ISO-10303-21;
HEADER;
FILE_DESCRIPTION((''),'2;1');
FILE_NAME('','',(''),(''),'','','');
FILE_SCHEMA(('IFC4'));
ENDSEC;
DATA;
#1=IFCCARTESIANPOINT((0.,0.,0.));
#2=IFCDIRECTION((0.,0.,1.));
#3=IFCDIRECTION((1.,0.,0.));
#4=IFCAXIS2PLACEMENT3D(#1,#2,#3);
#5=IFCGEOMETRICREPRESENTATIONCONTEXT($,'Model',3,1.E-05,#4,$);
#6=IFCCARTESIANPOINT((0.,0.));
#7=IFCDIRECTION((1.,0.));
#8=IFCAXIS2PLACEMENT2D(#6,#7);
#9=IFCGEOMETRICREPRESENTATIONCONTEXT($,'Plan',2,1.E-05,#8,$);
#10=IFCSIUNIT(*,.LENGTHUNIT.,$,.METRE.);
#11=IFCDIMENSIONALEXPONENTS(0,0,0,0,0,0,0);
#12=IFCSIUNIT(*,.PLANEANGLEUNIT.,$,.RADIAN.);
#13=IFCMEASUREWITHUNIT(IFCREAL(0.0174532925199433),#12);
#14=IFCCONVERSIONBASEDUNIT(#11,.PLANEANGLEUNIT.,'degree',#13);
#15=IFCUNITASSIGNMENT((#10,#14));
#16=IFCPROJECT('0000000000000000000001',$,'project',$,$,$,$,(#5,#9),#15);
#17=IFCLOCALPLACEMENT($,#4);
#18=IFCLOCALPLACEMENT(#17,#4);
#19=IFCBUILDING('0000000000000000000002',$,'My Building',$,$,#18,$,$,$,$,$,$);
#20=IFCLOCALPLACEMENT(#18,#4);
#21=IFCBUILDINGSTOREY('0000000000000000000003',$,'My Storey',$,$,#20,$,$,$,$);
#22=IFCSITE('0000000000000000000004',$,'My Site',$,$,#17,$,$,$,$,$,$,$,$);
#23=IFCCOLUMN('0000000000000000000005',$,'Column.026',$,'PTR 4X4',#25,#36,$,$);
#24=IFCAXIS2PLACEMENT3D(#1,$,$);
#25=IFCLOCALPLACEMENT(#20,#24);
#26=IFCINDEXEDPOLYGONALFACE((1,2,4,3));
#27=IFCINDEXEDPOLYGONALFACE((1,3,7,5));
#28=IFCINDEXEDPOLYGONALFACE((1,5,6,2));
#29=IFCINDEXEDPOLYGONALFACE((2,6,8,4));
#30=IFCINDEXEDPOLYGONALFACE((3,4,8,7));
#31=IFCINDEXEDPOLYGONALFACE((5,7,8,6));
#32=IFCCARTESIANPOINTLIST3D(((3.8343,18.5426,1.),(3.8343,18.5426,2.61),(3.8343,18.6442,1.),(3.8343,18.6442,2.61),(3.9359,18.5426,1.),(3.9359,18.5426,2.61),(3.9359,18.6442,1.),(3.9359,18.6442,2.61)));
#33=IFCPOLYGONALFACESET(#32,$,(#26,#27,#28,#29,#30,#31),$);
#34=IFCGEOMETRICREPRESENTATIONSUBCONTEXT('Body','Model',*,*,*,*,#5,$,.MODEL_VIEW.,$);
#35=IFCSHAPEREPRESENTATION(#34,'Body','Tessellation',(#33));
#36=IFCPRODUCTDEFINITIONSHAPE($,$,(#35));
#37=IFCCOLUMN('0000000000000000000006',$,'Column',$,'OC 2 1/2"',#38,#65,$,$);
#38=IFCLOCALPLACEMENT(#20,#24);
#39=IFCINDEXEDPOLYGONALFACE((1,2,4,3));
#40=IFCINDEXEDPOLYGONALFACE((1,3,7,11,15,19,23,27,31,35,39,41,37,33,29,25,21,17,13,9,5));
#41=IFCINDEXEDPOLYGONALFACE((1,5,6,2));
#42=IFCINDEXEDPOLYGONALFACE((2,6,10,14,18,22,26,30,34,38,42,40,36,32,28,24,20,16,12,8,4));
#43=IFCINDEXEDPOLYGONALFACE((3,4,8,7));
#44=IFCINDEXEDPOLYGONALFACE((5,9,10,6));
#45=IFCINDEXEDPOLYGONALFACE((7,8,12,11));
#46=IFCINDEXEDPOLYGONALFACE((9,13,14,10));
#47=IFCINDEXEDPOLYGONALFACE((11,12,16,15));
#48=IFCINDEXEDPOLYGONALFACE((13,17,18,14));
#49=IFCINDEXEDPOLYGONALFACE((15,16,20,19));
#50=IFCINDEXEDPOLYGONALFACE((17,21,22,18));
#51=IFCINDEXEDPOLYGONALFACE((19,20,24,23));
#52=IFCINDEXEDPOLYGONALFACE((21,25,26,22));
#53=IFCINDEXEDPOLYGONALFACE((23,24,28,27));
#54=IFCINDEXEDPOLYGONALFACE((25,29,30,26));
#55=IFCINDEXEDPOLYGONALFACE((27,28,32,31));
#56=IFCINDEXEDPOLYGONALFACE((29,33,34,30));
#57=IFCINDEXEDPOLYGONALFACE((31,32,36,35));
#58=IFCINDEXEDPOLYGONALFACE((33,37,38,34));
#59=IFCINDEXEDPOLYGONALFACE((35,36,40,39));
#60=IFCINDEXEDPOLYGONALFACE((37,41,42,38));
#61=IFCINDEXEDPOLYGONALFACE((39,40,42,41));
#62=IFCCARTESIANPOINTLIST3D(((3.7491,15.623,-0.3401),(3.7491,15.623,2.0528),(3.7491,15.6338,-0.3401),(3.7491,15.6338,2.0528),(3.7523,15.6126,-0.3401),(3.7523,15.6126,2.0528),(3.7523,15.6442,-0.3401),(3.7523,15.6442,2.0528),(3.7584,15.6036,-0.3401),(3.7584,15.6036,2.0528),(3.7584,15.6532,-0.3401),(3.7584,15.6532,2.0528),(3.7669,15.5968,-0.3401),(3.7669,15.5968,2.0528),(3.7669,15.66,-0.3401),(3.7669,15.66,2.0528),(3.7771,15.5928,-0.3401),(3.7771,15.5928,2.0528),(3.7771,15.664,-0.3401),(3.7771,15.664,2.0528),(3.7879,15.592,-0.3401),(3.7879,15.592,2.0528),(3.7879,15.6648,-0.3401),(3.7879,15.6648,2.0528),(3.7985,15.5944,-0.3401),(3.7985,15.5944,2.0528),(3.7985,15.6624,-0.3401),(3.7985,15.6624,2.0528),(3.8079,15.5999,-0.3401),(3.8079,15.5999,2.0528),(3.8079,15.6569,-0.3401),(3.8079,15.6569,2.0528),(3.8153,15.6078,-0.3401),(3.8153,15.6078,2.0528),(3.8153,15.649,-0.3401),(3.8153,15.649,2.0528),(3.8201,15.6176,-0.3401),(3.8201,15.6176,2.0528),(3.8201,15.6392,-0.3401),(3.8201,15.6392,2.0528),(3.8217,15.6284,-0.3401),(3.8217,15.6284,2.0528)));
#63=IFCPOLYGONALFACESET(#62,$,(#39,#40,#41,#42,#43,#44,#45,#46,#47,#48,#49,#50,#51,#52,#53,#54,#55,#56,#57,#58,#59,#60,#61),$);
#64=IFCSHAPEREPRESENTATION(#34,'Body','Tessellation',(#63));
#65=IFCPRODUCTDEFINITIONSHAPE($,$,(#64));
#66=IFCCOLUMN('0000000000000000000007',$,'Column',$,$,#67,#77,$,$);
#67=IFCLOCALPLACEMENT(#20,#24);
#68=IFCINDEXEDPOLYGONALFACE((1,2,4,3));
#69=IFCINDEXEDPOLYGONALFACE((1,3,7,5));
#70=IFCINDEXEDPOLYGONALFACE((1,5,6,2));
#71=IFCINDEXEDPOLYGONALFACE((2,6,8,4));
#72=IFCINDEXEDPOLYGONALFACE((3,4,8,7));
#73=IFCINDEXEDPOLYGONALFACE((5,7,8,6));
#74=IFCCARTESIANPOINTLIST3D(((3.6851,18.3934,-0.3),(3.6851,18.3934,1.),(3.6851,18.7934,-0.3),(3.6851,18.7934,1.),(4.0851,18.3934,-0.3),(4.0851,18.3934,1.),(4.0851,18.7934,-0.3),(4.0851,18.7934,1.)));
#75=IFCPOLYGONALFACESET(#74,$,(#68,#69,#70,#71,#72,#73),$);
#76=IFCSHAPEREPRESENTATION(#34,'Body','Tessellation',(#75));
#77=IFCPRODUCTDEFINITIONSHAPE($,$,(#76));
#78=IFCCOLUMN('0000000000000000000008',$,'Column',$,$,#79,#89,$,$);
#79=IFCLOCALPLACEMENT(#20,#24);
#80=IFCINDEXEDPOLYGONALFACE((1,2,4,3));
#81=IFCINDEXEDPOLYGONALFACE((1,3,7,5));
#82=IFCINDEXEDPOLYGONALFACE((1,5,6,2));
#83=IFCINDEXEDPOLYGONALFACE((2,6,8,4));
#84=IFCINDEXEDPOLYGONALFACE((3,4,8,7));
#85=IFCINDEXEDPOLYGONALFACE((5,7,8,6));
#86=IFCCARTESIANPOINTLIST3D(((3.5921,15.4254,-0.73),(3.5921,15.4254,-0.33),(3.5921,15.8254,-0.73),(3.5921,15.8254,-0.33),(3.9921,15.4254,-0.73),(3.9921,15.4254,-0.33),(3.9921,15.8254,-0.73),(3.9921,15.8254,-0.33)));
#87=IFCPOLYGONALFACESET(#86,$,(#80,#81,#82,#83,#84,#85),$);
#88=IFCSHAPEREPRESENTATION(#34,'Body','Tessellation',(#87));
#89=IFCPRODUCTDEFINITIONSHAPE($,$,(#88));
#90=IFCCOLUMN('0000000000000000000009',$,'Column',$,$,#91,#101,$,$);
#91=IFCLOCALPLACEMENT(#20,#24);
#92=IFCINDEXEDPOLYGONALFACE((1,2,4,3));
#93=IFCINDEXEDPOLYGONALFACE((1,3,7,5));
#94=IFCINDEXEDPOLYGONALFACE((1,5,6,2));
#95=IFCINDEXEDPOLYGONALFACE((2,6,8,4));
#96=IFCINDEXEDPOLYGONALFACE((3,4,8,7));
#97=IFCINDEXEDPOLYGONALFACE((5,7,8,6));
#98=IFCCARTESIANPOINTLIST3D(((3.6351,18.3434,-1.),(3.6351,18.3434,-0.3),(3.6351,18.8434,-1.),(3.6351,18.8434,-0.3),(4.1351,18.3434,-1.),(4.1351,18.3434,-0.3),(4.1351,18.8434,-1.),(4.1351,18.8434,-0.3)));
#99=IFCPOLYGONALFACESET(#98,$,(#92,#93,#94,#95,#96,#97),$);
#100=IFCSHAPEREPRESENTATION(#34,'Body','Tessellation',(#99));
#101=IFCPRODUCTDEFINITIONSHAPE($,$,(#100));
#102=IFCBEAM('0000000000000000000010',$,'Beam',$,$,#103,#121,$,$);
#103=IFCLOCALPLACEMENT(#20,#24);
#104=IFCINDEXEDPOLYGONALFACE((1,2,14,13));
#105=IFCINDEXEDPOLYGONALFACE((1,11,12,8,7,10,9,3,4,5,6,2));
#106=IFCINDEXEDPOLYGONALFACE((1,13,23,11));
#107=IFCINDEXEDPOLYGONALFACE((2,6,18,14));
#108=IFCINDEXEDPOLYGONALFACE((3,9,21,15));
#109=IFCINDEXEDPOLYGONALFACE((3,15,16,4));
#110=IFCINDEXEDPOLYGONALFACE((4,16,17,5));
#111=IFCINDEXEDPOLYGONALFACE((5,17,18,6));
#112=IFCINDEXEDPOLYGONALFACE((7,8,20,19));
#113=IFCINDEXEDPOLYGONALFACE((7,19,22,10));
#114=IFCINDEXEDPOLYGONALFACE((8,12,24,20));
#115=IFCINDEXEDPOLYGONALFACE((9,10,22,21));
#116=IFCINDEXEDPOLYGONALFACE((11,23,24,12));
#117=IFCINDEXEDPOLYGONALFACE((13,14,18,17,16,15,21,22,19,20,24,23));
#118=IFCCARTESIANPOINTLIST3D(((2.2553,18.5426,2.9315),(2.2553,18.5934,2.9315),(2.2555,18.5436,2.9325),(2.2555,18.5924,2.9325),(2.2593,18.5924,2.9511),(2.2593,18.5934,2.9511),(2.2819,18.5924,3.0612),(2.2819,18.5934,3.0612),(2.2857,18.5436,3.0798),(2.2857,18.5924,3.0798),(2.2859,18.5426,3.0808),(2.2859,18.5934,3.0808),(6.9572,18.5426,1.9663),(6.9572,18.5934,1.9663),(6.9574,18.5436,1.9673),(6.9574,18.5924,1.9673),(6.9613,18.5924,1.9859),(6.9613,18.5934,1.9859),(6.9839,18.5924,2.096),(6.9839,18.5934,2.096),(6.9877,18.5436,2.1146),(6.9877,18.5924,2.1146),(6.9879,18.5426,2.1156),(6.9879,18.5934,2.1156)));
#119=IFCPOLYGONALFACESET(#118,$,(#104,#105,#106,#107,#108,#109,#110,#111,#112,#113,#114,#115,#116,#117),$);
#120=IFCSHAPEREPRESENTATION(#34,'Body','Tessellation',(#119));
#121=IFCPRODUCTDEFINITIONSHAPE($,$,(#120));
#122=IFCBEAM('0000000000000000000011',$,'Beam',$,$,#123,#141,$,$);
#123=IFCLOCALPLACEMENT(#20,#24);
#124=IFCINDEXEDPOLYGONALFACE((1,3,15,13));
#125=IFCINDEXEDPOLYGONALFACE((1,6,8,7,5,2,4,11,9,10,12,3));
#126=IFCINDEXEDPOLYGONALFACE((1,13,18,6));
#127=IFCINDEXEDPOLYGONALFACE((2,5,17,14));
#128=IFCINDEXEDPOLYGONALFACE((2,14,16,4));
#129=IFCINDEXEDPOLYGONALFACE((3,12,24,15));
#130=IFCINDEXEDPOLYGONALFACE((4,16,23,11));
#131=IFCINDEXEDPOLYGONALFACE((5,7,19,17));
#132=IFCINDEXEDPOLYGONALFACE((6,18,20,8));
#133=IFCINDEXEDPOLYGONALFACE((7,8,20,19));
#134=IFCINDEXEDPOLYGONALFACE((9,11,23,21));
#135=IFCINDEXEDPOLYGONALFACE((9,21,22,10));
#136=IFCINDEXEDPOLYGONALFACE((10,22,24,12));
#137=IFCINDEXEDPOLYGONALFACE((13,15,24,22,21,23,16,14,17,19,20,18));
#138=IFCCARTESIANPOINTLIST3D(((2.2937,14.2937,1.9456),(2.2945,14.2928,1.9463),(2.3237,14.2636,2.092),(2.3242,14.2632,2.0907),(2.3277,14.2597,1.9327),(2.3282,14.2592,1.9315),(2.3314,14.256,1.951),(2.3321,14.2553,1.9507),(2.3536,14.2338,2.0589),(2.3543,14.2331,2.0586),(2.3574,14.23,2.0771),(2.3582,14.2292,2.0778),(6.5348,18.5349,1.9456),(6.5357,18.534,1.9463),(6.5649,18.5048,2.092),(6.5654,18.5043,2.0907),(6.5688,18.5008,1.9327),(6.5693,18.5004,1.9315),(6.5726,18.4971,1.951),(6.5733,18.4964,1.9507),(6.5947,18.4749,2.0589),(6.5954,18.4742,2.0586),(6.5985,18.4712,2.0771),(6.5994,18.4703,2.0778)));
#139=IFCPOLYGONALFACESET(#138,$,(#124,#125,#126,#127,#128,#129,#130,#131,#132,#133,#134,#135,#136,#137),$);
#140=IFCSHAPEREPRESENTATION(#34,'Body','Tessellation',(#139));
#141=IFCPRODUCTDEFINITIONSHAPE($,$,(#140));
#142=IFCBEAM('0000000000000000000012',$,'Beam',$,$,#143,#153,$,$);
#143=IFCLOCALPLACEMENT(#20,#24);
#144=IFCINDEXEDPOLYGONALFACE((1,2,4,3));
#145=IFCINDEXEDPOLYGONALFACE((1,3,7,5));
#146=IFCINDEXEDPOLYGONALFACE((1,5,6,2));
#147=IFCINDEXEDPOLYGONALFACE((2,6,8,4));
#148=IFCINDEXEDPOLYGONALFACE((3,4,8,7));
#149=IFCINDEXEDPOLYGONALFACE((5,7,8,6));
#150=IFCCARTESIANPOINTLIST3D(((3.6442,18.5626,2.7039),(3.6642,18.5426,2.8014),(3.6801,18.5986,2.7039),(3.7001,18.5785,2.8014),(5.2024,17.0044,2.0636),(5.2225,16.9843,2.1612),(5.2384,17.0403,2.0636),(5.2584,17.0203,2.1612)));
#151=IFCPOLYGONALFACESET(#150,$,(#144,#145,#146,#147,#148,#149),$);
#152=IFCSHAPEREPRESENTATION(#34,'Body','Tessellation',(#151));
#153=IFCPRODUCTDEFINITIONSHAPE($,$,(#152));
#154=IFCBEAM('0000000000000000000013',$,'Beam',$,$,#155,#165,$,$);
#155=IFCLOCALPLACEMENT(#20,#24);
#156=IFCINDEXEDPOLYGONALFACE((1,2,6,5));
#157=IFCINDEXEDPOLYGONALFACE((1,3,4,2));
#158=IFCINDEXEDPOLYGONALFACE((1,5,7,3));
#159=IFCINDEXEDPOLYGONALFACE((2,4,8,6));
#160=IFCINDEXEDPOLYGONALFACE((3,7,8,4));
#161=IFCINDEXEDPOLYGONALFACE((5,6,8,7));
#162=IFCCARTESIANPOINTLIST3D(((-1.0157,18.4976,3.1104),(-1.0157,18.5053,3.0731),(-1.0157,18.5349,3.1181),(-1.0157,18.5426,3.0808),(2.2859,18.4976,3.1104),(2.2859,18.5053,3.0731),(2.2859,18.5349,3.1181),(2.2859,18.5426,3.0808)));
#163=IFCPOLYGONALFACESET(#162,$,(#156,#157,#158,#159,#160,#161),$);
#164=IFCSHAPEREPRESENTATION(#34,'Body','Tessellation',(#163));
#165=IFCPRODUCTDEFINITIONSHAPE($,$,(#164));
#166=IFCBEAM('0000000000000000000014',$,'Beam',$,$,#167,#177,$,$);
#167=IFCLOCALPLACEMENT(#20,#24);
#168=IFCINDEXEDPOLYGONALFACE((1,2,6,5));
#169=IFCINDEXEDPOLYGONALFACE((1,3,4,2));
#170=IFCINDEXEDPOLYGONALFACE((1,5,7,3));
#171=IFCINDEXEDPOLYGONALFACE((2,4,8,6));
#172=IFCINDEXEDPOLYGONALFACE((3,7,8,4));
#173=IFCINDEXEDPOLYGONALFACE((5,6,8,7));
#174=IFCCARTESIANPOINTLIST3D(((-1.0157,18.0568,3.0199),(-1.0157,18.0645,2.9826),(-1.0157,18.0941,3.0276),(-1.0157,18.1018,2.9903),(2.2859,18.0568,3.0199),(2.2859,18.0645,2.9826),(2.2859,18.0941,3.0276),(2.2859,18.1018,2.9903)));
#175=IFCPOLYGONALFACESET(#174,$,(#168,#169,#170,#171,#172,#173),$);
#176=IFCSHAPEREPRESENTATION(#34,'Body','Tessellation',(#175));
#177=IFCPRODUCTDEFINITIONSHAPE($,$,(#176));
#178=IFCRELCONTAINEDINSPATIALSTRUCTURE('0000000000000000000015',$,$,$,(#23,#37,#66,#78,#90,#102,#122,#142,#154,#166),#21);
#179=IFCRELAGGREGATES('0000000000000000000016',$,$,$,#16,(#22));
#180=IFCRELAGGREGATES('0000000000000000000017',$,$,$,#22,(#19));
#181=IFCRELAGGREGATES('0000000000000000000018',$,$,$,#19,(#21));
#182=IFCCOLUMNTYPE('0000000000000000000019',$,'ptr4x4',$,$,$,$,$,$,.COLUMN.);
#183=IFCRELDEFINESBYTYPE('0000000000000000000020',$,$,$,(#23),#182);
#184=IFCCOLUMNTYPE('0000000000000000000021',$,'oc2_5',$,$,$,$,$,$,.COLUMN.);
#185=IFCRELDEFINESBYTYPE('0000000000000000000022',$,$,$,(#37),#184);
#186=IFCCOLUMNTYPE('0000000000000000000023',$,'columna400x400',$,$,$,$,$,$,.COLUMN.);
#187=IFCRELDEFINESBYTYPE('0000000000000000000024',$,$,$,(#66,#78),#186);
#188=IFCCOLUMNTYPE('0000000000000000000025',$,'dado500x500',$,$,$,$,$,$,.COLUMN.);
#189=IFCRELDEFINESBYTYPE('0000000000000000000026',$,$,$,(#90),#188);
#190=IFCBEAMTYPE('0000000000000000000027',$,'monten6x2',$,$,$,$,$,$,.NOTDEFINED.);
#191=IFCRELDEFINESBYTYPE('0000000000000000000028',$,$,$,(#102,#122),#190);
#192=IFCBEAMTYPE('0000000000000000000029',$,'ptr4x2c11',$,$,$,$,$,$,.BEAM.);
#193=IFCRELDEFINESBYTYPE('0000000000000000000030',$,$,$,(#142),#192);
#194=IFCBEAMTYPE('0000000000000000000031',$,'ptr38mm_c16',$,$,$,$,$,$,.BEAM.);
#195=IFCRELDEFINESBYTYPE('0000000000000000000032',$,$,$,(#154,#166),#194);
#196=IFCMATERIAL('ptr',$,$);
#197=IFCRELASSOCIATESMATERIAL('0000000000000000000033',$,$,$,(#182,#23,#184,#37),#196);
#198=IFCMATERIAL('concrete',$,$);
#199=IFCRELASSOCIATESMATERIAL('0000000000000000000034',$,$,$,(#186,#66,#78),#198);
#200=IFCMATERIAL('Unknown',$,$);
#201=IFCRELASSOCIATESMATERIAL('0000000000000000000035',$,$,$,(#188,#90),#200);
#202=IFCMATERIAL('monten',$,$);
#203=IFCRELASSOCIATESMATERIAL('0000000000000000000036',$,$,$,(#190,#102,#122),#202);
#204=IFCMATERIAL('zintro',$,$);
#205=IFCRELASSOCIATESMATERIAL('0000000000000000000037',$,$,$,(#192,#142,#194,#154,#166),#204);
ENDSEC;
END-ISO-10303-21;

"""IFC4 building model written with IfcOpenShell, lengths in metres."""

from ifc_helpers import new_model, entity, si_unit, converted_unit, frame, origin_with_axes, origin_2d_with_axis, place, context, subcontext, project, spatial, rectangle, circle, c_section, extrude, material, material_profile, profile_set, profile_usage, type_object, element, save


model = new_model("IFC4")

# Units and contexts
model_context = context("Model", 3, precision=1e-05, world=origin_with_axes())
plan_context = context("Plan", 2, precision=1e-05, world=origin_2d_with_axis())
body_context = subcontext(model_context, "Body", "Model", "MODEL_VIEW")
ifc_project = project(units=[si_unit("LENGTHUNIT", "METRE"), converted_unit("PLANEANGLEUNIT", "degree", entity("IfcReal", 0.0174532925199433), si_unit("PLANEANGLEUNIT", "RADIAN"), dimensions=[0, 0, 0, 0, 0, 0, 0])], contexts=[model_context, plan_context])

# Site, building, storey
site_placement = place(None, origin_with_axes())
site = spatial("IfcSite", under=ifc_project, at=site_placement, Name="My Site")
building_placement = place(site_placement, origin_with_axes())
building = spatial("IfcBuilding", under=site, at=building_placement, Name="My Building")
storey_placement = place(building_placement, origin_with_axes())
storey = spatial("IfcBuildingStorey", under=building, at=storey_placement, Name="My Storey")

# Columns
ifc_material_1 = material(Name="ptr")
ifc_material_profile_1 = material_profile(ifc_material_1, rectangle(XDim=0.1016, YDim=0.1016))
ifc_profile_set_1 = profile_set([ifc_material_profile_1])
ifc_profile_usage_1 = profile_usage(ifc_profile_set_1, cardinal=5)
column_type_1 = type_object("IfcColumnType", Name="ptr4x4", PredefinedType="COLUMN", material=ifc_profile_set_1)
column_1_placement = place(storey_placement, frame((3.8851, 18.5934, 1.0), z_axis=(0.0, 0.0, 1.0), x_axis=(0.0, 1.0, 0.0)))
element("IfcColumn", 1, at=column_1_placement, inside=storey, type_object=column_type_1, material=ifc_profile_usage_1, Name="Column.026", ObjectType="PTR 4X4", context=body_context, shape_type="SweptSolid", body=[
    extrude(rectangle(XDim=0.1016, YDim=0.1016), origin_with_axes(), (0.0, 0.0, 1.0), 1.61),
])
ifc_material_profile_2 = material_profile(ifc_material_1, circle(Radius=0.0365))
ifc_profile_set_2 = profile_set([ifc_material_profile_2])
ifc_profile_usage_2 = profile_usage(ifc_profile_set_2)
column_type_2 = type_object("IfcColumnType", Name="oc2_5", PredefinedType="COLUMN", material=ifc_profile_set_2)
column_2_placement = place(storey_placement, frame((3.7852, 15.6284, -0.3401), z_axis=(0.0, 0.0, 1.0), x_axis=(1.0, 0.0, 0.0)))
element("IfcColumn", 2, at=column_2_placement, inside=storey, type_object=column_type_2, material=ifc_profile_usage_2, Name="Column", ObjectType="OC 2 1/2\"", context=body_context, shape_type="SweptSolid", body=[
    extrude(circle(Radius=0.0365), origin_with_axes(), (0.0, 0.0, 1.0), 2.3929),
])
ifc_material_2 = material(Name="concrete")
ifc_material_profile_3 = material_profile(ifc_material_2, rectangle(XDim=0.4, YDim=0.4))
ifc_profile_set_3 = profile_set([ifc_material_profile_3], Name="concrete")
ifc_profile_usage_3 = profile_usage(ifc_profile_set_3)
column_type_3 = type_object("IfcColumnType", Name="columna400x400", PredefinedType="COLUMN", material=ifc_profile_set_3)
column_3_placement = place(storey_placement, frame((3.8851, 18.5934, -0.3), z_axis=(0.0, 0.0, 1.0), x_axis=(1.0, 0.0, 0.0)))
element("IfcColumn", 3, at=column_3_placement, inside=storey, type_object=column_type_3, material=ifc_profile_usage_3, Name="Column", context=body_context, shape_type="SweptSolid", body=[
    extrude(rectangle(XDim=0.4, YDim=0.4), origin_with_axes(), (0.0, 0.0, 1.0), 1.3),
])
ifc_profile_usage_4 = profile_usage(ifc_profile_set_3, cardinal=5)
column_4_placement = place(storey_placement, frame((3.7921, 15.6254, -0.73), z_axis=(0.0, 0.0, 1.0), x_axis=(1.0, 0.0, 0.0)))
element("IfcColumn", 4, at=column_4_placement, inside=storey, type_object=column_type_3, material=ifc_profile_usage_4, Name="Column", context=body_context, shape_type="SweptSolid", body=[
    extrude(rectangle(XDim=0.4, YDim=0.4), origin_with_axes(), (0.0, 0.0, 1.0), 0.4),
])
ifc_material_3 = material(Name="Unknown")
ifc_material_profile_4 = material_profile(ifc_material_3, rectangle(XDim=0.5, YDim=0.5))
ifc_profile_set_4 = profile_set([ifc_material_profile_4], Name="concrete")
ifc_profile_usage_5 = profile_usage(ifc_profile_set_4)
column_type_4 = type_object("IfcColumnType", Name="dado500x500", PredefinedType="COLUMN", material=ifc_profile_set_4)
column_5_placement = place(storey_placement, frame((3.8851, 18.5934, -1.0), z_axis=(0.0, 0.0, 1.0), x_axis=(1.0, 0.0, 0.0)))
element("IfcColumn", 5, at=column_5_placement, inside=storey, type_object=column_type_4, material=ifc_profile_usage_5, Name="Column", context=body_context, shape_type="SweptSolid", body=[
    extrude(rectangle(XDim=0.5, YDim=0.5), origin_with_axes(), (0.0, 0.0, 1.0), 0.7),
])

# Beams
ifc_material_4 = material(Name="monten")
ifc_material_profile_5 = material_profile(ifc_material_4, c_section(Depth=0.1524, Width=0.0508, WallThickness=0.001, Girth=0.02))
ifc_profile_set_5 = profile_set([ifc_material_profile_5])
ifc_profile_usage_6 = profile_usage(ifc_profile_set_5, cardinal=5)
beam_type_1 = type_object("IfcBeamType", Name="monten6x2", PredefinedType="NOTDEFINED", material=ifc_profile_set_5)
beam_1_placement = place(storey_placement, frame((2.2706, 18.568, 3.0061), z_axis=(0.979575, 0.0, -0.201078), x_axis=(0.0, 1.0, 0.0)))
element("IfcBeam", 6, at=beam_1_placement, inside=storey, type_object=beam_type_1, material=ifc_profile_usage_6, Name="Beam", context=body_context, shape_type="SweptSolid", body=[
    extrude(c_section(Depth=0.1524, Width=0.0508, WallThickness=0.001, Girth=0.02), origin_with_axes(), (0.0, 0.0, 1.0), 4.8),
])
ifc_profile_usage_7 = profile_usage(ifc_profile_set_5, cardinal=5)
beam_2_placement = place(storey_placement, frame((2.3259, 14.2614, 2.0117), z_axis=(0.707107, 0.707107, 0.0), x_axis=(0.679031, -0.67903, -0.27899)))
element("IfcBeam", 7, at=beam_2_placement, inside=storey, type_object=beam_type_1, material=ifc_profile_usage_7, Name="Beam", context=body_context, shape_type="SweptSolid", body=[
    extrude(c_section(Depth=0.1524, Width=0.0508, WallThickness=0.001, Girth=0.02), origin_with_axes(), (0.0, 0.0, 1.0), 5.9979),
])
ifc_material_5 = material(Name="zintro")
ifc_material_profile_6 = material_profile(ifc_material_5, rectangle(XDim=0.0508, YDim=0.1016))
ifc_profile_set_6 = profile_set([ifc_material_profile_6])
ifc_profile_usage_8 = profile_usage(ifc_profile_set_6)
beam_type_2 = type_object("IfcBeamType", Name="ptr4x2c11", PredefinedType="BEAM", material=ifc_profile_set_6)
beam_3_placement = place(storey_placement, frame((3.6722, 18.5706, 2.7527), z_axis=(0.67903, -0.67903, -0.278991), x_axis=(0.707107, 0.707107, 0.0)))
element("IfcBeam", 8, at=beam_3_placement, inside=storey, type_object=beam_type_2, material=ifc_profile_usage_8, Name="Beam", context=body_context, shape_type="SweptSolid", body=[
    extrude(rectangle(XDim=0.0508, YDim=0.1016), origin_with_axes(), (0.0, 0.0, 1.0), 2.2948),
])
ifc_material_profile_7 = material_profile(ifc_material_5, rectangle(XDim=0.0381, YDim=0.0381))
ifc_profile_set_7 = profile_set([ifc_material_profile_7])
ifc_profile_usage_9 = profile_usage(ifc_profile_set_7)
beam_type_3 = type_object("IfcBeamType", Name="ptr38mm_c16", PredefinedType="BEAM", material=ifc_profile_set_7)
beam_4_placement = place(storey_placement, frame((2.2859, 18.5201, 3.0956), z_axis=(-1.0, 0.0, 0.0), x_axis=(0.0, -0.979575, -0.201078)))
element("IfcBeam", 9, at=beam_4_placement, inside=storey, type_object=beam_type_3, material=ifc_profile_usage_9, Name="Beam", context=body_context, shape_type="SweptSolid", body=[
    extrude(rectangle(XDim=0.0381, YDim=0.0381), origin_with_axes(), (0.0, 0.0, 1.0), 3.3016),
])
ifc_profile_usage_10 = profile_usage(ifc_profile_set_7)
beam_5_placement = place(storey_placement, frame((2.2859, 18.0793, 3.0051), z_axis=(-1.0, 0.0, 0.0), x_axis=(0.0, -0.979575, -0.201078)))
element("IfcBeam", 10, at=beam_5_placement, inside=storey, type_object=beam_type_3, material=ifc_profile_usage_10, Name="Beam", context=body_context, shape_type="SweptSolid", body=[
    extrude(rectangle(XDim=0.0381, YDim=0.0381), origin_with_axes(), (0.0, 0.0, 1.0), 3.3016),
])

save(model, "model.ifc")
